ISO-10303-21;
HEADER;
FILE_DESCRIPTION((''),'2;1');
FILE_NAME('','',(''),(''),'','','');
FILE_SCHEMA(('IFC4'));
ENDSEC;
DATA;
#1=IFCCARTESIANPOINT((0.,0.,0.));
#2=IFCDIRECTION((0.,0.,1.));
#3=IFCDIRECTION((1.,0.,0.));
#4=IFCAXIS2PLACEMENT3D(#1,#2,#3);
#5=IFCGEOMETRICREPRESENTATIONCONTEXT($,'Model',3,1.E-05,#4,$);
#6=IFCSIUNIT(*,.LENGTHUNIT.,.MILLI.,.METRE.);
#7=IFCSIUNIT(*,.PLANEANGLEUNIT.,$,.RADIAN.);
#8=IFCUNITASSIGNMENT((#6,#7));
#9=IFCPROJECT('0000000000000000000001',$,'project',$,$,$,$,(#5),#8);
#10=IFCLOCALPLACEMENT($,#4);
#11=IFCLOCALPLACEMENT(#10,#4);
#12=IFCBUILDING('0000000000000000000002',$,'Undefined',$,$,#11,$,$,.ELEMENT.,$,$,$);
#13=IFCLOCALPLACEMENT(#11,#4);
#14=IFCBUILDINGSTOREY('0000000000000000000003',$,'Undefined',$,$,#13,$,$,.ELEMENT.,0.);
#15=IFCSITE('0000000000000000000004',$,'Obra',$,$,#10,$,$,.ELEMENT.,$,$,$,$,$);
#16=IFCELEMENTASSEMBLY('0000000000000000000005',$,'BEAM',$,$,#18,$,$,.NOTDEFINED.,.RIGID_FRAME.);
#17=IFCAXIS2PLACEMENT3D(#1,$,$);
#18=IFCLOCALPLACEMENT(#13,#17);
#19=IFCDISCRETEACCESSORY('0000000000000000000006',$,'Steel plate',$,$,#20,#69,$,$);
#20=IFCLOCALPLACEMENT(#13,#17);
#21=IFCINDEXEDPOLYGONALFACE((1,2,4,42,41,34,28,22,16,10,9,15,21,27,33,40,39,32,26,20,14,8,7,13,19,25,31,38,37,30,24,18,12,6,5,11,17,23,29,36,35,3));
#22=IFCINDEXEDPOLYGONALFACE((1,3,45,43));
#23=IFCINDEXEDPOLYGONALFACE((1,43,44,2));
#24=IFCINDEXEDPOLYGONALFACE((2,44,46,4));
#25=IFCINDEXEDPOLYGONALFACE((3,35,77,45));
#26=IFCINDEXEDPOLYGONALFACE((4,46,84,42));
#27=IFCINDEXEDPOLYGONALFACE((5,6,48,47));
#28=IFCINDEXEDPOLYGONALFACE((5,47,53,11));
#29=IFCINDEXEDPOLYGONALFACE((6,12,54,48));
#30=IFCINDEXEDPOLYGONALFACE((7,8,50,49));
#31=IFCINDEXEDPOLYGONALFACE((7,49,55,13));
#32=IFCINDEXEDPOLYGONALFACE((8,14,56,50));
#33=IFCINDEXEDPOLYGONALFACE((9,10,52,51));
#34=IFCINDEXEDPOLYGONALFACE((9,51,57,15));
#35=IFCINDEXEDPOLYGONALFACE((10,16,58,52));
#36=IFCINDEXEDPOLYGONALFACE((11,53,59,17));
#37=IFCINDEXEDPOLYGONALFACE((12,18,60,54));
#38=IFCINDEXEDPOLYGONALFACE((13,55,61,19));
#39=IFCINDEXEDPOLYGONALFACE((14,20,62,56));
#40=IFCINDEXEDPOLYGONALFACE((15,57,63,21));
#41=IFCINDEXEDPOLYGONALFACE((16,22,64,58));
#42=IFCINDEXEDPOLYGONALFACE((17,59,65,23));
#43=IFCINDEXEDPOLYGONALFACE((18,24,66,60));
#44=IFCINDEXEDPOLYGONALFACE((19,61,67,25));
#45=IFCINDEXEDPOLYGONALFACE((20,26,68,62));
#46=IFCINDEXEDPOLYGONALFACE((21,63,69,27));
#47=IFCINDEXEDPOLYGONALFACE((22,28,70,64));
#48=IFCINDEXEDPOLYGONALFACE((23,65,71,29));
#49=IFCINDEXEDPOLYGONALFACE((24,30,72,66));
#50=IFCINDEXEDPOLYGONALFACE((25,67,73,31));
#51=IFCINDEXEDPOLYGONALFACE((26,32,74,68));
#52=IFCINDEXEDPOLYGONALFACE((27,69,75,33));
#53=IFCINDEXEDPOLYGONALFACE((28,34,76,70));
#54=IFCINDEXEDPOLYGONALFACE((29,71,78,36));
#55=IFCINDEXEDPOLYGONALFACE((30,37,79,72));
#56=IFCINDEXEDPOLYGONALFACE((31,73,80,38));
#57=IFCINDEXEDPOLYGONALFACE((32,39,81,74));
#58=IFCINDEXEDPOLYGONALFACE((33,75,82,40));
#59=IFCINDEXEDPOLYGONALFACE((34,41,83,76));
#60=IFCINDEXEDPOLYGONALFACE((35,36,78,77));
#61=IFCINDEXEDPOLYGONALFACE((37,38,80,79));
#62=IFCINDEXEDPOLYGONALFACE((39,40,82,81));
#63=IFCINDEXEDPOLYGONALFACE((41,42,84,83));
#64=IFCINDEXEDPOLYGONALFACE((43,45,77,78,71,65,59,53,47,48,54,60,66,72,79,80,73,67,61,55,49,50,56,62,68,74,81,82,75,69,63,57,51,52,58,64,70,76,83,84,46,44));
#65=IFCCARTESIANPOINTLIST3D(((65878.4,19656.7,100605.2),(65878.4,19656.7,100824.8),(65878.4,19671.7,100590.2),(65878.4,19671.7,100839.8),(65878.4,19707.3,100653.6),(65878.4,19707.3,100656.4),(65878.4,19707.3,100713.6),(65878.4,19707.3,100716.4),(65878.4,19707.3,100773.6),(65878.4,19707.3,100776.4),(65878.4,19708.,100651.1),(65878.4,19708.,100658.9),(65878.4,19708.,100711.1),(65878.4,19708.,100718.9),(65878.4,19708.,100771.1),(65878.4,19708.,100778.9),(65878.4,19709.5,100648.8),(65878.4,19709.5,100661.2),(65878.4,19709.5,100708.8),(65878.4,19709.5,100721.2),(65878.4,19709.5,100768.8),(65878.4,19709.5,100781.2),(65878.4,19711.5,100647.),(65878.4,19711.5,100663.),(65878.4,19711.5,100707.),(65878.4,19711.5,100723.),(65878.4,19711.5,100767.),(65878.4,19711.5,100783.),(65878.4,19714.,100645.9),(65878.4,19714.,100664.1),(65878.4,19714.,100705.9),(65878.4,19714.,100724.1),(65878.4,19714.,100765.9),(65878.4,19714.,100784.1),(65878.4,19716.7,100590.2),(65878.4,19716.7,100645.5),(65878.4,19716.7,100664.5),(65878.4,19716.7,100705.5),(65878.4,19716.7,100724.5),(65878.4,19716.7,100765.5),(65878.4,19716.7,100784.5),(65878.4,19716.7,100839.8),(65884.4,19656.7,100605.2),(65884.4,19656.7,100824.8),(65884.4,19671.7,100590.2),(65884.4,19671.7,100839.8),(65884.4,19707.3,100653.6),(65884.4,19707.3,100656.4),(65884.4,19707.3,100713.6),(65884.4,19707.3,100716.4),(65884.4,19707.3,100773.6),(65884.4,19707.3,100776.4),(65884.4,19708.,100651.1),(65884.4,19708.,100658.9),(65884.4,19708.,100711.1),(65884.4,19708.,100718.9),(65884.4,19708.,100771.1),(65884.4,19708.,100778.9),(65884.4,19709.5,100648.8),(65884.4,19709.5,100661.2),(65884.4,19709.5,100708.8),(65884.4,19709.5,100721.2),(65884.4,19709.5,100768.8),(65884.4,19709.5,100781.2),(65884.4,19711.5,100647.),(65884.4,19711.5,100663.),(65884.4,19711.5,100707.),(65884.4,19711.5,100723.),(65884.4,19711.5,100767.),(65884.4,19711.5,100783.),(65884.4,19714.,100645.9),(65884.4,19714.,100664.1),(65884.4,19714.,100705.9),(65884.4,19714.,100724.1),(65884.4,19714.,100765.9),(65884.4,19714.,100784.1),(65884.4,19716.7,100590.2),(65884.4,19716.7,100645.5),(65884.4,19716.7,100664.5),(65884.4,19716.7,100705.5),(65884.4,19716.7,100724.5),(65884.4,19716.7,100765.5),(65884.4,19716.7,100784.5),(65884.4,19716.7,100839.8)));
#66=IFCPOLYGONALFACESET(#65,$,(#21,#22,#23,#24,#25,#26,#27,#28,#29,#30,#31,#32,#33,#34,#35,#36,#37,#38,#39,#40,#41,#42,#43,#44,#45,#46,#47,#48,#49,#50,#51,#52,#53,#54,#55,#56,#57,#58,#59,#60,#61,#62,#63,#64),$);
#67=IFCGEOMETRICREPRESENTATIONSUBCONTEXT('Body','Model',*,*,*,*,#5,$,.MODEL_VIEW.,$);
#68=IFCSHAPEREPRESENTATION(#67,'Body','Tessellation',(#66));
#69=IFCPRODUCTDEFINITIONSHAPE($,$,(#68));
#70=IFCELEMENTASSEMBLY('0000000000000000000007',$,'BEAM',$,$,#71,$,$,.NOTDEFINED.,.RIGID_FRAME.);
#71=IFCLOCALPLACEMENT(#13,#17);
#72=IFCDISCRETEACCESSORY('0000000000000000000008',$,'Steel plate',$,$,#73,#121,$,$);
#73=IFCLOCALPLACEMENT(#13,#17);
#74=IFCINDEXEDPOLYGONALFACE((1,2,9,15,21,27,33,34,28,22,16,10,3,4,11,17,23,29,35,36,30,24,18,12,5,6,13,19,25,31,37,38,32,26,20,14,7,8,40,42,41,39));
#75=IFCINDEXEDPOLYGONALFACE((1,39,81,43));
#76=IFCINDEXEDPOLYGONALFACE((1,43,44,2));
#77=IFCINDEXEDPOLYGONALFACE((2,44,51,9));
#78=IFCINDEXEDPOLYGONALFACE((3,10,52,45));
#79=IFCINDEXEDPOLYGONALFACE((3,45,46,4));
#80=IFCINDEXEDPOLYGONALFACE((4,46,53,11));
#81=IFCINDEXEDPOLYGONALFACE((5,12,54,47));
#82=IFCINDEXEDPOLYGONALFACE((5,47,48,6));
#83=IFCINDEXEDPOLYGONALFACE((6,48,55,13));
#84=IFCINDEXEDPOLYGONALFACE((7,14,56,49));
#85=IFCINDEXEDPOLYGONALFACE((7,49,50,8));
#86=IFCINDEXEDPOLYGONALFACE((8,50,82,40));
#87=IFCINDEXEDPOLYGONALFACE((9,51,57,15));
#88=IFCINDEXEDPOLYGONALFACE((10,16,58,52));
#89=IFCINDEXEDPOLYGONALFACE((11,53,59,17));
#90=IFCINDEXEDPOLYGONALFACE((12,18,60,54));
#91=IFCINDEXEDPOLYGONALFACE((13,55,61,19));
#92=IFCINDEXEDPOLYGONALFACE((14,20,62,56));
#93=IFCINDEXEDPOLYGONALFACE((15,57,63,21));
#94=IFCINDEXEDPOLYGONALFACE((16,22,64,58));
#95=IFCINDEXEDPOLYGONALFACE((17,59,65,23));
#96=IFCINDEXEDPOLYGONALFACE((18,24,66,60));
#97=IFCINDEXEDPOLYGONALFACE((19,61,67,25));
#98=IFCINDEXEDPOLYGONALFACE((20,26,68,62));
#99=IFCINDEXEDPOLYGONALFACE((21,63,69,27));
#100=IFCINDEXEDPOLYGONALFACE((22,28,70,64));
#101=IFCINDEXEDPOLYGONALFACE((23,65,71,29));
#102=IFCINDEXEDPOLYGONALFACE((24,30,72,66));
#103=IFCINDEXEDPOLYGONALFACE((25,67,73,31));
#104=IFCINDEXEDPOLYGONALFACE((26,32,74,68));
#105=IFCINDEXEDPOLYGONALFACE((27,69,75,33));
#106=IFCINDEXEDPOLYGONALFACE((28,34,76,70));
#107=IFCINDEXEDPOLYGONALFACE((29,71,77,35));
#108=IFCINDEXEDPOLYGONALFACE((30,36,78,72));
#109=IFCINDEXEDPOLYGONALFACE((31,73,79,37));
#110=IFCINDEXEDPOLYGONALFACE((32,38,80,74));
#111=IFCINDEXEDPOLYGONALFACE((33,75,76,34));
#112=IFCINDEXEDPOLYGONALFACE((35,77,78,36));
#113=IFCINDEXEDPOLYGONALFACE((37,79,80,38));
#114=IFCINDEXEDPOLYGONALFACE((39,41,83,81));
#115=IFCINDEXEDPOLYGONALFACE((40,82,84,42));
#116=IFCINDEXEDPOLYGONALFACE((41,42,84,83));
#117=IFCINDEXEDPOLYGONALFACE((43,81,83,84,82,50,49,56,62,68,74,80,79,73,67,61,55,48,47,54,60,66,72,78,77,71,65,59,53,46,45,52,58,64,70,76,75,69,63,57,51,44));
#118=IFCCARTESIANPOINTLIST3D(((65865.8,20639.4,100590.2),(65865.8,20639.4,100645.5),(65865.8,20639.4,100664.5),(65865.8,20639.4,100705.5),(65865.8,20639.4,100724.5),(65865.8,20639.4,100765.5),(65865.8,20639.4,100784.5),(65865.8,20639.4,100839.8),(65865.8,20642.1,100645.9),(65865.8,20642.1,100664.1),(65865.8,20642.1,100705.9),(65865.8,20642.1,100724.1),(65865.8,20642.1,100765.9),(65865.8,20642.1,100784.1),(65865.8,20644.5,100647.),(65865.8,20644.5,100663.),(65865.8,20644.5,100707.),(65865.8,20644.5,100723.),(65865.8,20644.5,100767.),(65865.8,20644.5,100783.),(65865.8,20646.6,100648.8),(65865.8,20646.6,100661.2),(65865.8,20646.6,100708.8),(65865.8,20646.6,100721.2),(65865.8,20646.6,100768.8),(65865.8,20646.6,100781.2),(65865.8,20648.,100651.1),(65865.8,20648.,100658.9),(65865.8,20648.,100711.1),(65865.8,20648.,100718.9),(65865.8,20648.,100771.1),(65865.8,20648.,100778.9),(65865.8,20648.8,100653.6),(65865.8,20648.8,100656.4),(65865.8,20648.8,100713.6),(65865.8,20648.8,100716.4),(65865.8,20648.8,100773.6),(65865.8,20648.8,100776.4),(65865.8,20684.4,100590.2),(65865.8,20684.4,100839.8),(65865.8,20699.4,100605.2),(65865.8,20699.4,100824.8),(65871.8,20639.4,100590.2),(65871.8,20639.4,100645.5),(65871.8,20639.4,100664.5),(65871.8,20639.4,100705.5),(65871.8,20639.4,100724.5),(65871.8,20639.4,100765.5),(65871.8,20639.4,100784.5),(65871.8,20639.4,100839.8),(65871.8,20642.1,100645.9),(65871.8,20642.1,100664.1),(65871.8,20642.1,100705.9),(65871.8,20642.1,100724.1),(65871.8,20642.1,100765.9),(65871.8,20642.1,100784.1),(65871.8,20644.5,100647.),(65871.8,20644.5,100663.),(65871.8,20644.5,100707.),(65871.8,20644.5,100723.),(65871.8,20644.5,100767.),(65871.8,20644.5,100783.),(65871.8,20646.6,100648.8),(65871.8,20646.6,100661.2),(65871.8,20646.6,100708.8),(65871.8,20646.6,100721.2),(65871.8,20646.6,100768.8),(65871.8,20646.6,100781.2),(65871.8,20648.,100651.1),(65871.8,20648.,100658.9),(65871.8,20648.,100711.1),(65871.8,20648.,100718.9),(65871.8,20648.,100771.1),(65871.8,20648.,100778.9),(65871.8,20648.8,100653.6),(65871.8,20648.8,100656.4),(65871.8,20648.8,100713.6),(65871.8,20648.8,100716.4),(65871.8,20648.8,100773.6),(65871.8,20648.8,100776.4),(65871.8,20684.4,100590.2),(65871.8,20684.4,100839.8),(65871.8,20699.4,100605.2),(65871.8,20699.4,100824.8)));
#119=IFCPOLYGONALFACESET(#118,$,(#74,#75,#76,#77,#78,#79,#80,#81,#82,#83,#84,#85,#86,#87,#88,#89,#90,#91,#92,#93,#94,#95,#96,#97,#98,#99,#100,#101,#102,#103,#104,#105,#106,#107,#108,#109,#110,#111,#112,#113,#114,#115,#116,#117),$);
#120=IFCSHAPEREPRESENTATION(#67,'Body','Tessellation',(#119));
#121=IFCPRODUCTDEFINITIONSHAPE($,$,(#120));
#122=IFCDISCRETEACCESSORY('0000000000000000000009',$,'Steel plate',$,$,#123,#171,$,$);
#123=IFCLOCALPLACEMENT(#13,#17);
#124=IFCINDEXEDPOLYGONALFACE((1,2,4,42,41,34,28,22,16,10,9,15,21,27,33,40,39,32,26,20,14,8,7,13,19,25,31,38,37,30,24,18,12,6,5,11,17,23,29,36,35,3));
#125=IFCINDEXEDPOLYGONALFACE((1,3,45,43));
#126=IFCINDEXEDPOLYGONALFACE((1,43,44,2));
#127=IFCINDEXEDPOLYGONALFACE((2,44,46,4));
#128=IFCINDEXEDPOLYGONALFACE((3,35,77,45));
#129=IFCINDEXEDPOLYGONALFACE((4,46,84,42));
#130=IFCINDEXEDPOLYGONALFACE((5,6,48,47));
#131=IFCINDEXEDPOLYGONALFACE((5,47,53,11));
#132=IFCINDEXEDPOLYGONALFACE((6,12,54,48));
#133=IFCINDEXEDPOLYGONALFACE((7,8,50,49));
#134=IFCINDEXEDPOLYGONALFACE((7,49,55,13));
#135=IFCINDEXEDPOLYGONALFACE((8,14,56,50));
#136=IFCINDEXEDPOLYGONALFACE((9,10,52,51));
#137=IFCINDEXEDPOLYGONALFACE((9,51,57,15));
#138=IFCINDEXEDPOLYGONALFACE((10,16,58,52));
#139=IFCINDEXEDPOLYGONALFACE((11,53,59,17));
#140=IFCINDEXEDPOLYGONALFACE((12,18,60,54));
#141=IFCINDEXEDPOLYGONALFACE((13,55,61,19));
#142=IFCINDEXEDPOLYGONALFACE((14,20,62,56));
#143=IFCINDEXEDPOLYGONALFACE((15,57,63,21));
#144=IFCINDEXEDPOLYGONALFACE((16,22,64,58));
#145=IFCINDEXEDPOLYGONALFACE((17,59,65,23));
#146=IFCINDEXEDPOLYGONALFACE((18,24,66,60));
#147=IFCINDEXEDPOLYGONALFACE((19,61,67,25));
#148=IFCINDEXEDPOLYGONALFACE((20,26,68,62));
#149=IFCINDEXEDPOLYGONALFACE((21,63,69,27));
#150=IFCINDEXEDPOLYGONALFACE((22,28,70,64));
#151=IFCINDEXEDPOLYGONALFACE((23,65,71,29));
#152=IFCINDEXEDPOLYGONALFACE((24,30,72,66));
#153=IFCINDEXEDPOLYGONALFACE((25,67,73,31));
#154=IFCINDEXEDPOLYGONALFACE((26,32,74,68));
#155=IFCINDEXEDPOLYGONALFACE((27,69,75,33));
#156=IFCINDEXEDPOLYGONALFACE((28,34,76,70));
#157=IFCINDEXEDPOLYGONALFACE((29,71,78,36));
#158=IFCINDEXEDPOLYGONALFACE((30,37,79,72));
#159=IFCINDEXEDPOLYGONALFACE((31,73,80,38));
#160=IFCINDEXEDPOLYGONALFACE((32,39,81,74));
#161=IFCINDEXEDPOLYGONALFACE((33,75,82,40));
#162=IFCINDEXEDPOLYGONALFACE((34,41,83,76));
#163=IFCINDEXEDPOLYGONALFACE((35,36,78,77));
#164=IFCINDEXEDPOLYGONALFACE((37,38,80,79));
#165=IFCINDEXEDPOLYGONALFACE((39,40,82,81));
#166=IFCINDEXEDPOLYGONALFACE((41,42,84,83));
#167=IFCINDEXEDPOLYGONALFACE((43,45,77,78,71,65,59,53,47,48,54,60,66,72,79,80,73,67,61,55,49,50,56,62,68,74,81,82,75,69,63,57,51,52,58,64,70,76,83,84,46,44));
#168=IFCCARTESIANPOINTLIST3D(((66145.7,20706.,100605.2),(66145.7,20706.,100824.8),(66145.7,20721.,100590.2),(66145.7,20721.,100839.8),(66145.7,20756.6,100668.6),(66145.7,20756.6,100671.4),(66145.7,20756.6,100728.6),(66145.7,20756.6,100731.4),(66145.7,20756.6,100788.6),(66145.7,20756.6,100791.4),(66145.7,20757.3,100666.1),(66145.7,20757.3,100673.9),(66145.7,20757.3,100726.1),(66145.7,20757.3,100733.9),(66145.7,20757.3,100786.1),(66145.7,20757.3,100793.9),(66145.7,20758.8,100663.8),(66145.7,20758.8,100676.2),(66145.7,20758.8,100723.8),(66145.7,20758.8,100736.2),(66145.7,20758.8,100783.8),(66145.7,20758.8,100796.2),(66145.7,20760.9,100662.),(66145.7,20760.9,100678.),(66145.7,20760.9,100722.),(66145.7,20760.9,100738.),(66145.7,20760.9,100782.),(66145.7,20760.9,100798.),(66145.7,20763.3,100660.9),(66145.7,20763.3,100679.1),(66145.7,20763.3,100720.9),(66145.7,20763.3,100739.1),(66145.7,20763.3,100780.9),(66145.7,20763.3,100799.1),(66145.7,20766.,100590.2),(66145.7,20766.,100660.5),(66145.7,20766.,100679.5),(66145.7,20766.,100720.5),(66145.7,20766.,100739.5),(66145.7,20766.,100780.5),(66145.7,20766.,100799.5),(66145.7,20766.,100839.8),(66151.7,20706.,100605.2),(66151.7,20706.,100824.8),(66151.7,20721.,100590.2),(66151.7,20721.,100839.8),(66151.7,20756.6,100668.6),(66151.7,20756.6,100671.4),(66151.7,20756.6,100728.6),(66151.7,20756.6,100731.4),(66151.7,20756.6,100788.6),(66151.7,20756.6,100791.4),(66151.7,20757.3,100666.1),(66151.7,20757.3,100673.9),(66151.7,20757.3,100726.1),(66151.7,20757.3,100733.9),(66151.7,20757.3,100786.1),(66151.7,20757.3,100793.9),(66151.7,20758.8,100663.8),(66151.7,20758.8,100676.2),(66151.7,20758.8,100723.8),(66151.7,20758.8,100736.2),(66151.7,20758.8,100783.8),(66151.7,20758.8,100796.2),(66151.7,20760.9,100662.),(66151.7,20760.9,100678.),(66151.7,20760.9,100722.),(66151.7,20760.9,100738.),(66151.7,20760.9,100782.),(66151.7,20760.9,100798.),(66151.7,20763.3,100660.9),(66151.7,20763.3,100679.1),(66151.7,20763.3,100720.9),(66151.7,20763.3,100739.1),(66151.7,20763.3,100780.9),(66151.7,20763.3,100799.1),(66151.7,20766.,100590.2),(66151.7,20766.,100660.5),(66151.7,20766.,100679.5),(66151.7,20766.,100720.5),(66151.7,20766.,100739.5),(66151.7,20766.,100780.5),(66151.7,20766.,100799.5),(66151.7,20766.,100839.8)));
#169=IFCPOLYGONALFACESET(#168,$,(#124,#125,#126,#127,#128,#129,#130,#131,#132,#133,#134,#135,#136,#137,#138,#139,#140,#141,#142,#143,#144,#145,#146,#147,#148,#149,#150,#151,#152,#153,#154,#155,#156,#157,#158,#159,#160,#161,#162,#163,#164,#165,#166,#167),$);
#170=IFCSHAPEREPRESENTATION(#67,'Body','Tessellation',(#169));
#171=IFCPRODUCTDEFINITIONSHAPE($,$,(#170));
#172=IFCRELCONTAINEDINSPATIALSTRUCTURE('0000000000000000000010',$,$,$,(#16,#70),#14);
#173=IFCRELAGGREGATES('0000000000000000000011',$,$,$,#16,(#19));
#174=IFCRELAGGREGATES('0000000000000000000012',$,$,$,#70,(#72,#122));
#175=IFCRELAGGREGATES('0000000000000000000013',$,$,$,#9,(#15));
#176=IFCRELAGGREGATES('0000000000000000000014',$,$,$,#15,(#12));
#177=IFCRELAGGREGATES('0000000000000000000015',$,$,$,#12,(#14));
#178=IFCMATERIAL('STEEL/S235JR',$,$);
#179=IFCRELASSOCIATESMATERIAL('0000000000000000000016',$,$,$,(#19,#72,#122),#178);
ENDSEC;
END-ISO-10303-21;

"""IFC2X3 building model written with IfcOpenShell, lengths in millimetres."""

from ifc_helpers import new_model, si_unit, frame, origin_with_axes, origin_2d_with_axis, place, context, subcontext, project, spatial, polyline, circle, outline, extrude, source, transform, mapped, material, element, aggregate, save


model = new_model("IFC2X3")

# Units and contexts
model_context = context("Model", 3, precision=1e-05, world=origin_with_axes())
body_context = subcontext(model_context, "Body", "Model", "MODEL_VIEW")
ifc_project = project(units=[si_unit("LENGTHUNIT", "METRE", prefix="MILLI"), si_unit("PLANEANGLEUNIT", "RADIAN")], contexts=[model_context])

# Site, building, storey
site_placement = place(None, origin_with_axes())
site = spatial("IfcSite", under=ifc_project, at=site_placement, Name="Obra", CompositionType="ELEMENT")
building_placement = place(site_placement, origin_with_axes())
building = spatial("IfcBuilding", under=site, at=building_placement, Name="Undefined", CompositionType="ELEMENT")
storey_placement = place(building_placement, origin_with_axes())
storey = spatial("IfcBuildingStorey", under=building, at=storey_placement, Name="Undefined", CompositionType="ELEMENT", Elevation=0.0)

# Shared definitions
ifc_material = material(Name="STEEL/S235JR")

# Element assemblies, discrete accessories, openings
shared_shape_1 = source(origin_with_axes(), body_context, "Body", "SweptSolid", [
    extrude(circle(Radius=9.5, at=origin_2d_with_axis()), frame((0.0, -9.4, 0.0), z_axis=(0.0, 1.0, 0.0), x_axis=(1.0, 0.0, 0.0)), (0.0, 0.0, 1.0), 6.2),
])
assembly_1_placement = place(storey_placement, origin_with_axes())
assembly_1 = element("IfcElementAssembly", 1, at=assembly_1_placement, inside=storey, Name="BEAM", AssemblyPlace="NOTDEFINED", PredefinedType="RIGID_FRAME")
discrete_accessory_1_placement = place(assembly_1_placement, frame((65881.4, 19716.7, 100590.2), z_axis=(-1.0, -0.000002, 0.0), x_axis=(0.000002, -1.0, 0.0)))
discrete_accessory_1 = element("IfcDiscreteAccessory", 2, at=discrete_accessory_1_placement, material=ifc_material, Name="Steel plate", context=body_context, shape_type="SweptSolid", body=[
    extrude(outline(polyline([(0.0, 0.0), (45.0, 0.0), (60.0, 15.0), (60.0, 234.6), (45.0, 249.6), (0.0, 249.6), (0.0, 0.0)])), frame((0.0, 0.0, -3.0), z_axis=(0.0, 0.0, 1.0), x_axis=(1.0, 0.0, 0.0)), (0.0, 0.0, 1.0), 6.0),
])
opening_1_placement = place(assembly_1_placement, frame((65875.1, 19666.7, 100850.0), z_axis=(-0.000002, 1.0, 0.0), x_axis=(0.0, 0.0, -1.0)))
element("IfcOpeningElement", 3, at=opening_1_placement, cuts=discrete_accessory_1, ObjectType="Opening", context=body_context, shape_type="MappedRepresentation", body=[
    mapped(shared_shape_1, transform((75.0, 0.0, 50.0))),
    mapped(shared_shape_1, transform((135.0, 0.0, 50.0))),
    mapped(shared_shape_1, transform((195.0, 0.0, 50.0))),
])
aggregate(assembly_1, [discrete_accessory_1])
assembly_2_placement = place(storey_placement, origin_with_axes())
assembly_2 = element("IfcElementAssembly", 4, at=assembly_2_placement, inside=storey, Name="BEAM", AssemblyPlace="NOTDEFINED", PredefinedType="RIGID_FRAME")
discrete_accessory_2_placement = place(assembly_2_placement, frame((65868.8, 20639.4, 100590.2), z_axis=(1.0, 0.000001, 0.0), x_axis=(-0.000002, 1.0, 0.0)))
discrete_accessory_2 = element("IfcDiscreteAccessory", 5, at=discrete_accessory_2_placement, material=ifc_material, Name="Steel plate", context=body_context, shape_type="SweptSolid", body=[
    extrude(outline(polyline([(0.0, 0.0), (45.0, 0.0), (60.0, 15.0), (60.0, 234.6), (45.0, 249.6), (0.0, 249.6), (0.0, 0.0)])), frame((0.0, 0.0, -3.0), z_axis=(0.0, 0.0, 1.0), x_axis=(1.0, 0.0, 0.0)), (0.0, 0.0, 1.0), 6.0),
])
opening_2_placement = place(assembly_2_placement, frame((65875.1, 20689.4, 100850.0), z_axis=(0.000002, -1.0, 0.0), x_axis=(0.0, 0.0, -1.0)))
element("IfcOpeningElement", 6, at=opening_2_placement, cuts=discrete_accessory_2, ObjectType="Opening", context=body_context, shape_type="MappedRepresentation", body=[
    mapped(shared_shape_1, transform((75.0, 0.0, 50.0))),
    mapped(shared_shape_1, transform((135.0, 0.0, 50.0))),
    mapped(shared_shape_1, transform((195.0, 0.0, 50.0))),
])
discrete_accessory_3_placement = place(assembly_2_placement, frame((66148.7, 20766.0, 100590.2), z_axis=(-1.0, -0.000002, 0.0), x_axis=(0.000002, -1.0, 0.0)))
discrete_accessory_3 = element("IfcDiscreteAccessory", 7, at=discrete_accessory_3_placement, material=ifc_material, Name="Steel plate", context=body_context, shape_type="SweptSolid", body=[
    extrude(outline(polyline([(0.0, 0.0), (45.0, 0.0), (60.0, 15.0), (60.0, 234.6), (45.0, 249.6), (0.0, 249.6), (0.0, 0.0)])), frame((0.0, 0.0, -3.0), z_axis=(0.0, 0.0, 1.0), x_axis=(1.0, 0.0, 0.0)), (0.0, 0.0, 1.0), 6.0),
])
shared_shape_2 = source(origin_with_axes(), body_context, "Body", "SweptSolid", [
    extrude(circle(Radius=9.5, at=origin_2d_with_axis()), frame((0.0, -9.2, 0.0), z_axis=(0.0, 1.0, 0.0), x_axis=(1.0, 0.0, 0.0)), (0.0, 0.0, 1.0), 6.2),
])
opening_3_placement = place(assembly_2_placement, frame((66142.6, 20716.0, 100850.0), z_axis=(-0.000002, 1.0, 0.0), x_axis=(0.0, 0.0, -1.0)))
element("IfcOpeningElement", 8, at=opening_3_placement, cuts=discrete_accessory_3, ObjectType="Opening", context=body_context, shape_type="MappedRepresentation", body=[
    mapped(shared_shape_2, transform((60.0, 0.0, 50.0))),
    mapped(shared_shape_2, transform((120.0, 0.0, 50.0))),
    mapped(shared_shape_2, transform((180.0, 0.0, 50.0))),
])
aggregate(assembly_2, [discrete_accessory_2, discrete_accessory_3])

save(model, "model.ifc")
